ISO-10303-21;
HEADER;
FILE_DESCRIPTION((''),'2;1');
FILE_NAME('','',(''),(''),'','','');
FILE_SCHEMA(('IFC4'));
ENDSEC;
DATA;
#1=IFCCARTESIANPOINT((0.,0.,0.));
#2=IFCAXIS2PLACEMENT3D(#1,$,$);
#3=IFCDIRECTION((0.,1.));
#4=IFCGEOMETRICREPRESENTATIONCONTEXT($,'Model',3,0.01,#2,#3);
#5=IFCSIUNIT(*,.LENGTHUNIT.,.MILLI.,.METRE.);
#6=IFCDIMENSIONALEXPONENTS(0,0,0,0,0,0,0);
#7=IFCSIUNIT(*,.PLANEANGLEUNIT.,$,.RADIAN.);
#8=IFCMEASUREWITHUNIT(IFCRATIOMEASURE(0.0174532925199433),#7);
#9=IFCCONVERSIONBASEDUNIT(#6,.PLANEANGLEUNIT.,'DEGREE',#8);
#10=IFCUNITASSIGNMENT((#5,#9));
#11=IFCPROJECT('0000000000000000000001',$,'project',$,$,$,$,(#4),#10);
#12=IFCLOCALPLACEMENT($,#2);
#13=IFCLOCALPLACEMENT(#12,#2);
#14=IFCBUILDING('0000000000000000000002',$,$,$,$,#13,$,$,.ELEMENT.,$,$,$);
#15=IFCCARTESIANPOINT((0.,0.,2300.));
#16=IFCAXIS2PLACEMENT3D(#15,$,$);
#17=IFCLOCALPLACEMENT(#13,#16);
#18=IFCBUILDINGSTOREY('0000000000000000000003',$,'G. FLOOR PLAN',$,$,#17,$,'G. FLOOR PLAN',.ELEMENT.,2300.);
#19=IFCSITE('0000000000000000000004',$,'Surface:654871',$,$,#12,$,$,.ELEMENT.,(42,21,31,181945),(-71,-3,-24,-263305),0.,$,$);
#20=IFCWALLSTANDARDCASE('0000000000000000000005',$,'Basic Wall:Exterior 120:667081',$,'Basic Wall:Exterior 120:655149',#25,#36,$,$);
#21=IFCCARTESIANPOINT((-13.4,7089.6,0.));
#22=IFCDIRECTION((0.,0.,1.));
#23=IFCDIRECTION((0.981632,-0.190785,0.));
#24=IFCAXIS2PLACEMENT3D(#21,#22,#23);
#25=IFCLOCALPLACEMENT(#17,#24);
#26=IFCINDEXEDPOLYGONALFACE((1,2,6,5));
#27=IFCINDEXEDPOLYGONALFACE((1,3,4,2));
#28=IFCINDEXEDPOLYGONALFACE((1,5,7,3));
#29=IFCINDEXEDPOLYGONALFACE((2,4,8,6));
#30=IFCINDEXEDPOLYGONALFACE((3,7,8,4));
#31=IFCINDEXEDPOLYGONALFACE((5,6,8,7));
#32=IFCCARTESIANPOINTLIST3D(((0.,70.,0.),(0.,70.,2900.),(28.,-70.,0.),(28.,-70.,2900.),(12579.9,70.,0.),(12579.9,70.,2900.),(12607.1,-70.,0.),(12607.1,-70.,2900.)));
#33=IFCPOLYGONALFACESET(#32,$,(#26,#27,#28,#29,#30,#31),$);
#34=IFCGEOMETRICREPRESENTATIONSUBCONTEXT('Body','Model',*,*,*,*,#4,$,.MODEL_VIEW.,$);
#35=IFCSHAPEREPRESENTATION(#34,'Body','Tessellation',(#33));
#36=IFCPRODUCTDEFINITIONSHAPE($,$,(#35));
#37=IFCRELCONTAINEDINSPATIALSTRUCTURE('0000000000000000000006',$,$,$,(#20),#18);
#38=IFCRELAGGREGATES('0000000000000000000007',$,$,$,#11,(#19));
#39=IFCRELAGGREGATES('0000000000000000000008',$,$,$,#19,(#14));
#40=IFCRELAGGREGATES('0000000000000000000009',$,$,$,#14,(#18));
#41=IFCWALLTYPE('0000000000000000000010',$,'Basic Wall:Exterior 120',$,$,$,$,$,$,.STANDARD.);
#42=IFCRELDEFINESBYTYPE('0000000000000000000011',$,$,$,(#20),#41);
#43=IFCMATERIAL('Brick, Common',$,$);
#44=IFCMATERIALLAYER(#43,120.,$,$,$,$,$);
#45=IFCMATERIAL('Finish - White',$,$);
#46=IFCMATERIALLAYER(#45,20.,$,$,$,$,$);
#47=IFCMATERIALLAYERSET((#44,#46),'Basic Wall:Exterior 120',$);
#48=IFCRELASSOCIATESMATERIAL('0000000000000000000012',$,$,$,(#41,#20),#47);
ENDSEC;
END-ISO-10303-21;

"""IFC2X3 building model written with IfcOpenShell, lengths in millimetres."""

from ifc_helpers import new_model, entity, si_unit, converted_unit, direction, frame, origin, place, context, subcontext, project, spatial, polyline, outline, extrude, clip, bounded_halfspace, material, layer, layer_set, layer_usage, type_object, element, save


model = new_model("IFC2X3")

# Units and contexts
model_context = context("Model", 3, precision=0.01, world=origin(), true_north=direction((0.0, 1.0)))
body_context = subcontext(model_context, "Body", "Model", "MODEL_VIEW")
ifc_project = project(units=[si_unit("LENGTHUNIT", "METRE", prefix="MILLI"), converted_unit("PLANEANGLEUNIT", "DEGREE", entity("IfcRatioMeasure", 0.0174532925199433), si_unit("PLANEANGLEUNIT", "RADIAN"), dimensions=[0, 0, 0, 0, 0, 0, 0])], contexts=[model_context])

# Site, building, storey
site_placement = place(None, origin())
site = spatial("IfcSite", under=ifc_project, at=site_placement, Name="Surface:654871", CompositionType="ELEMENT", RefLatitude=(42, 21, 31, 181945), RefLongitude=(-71, -3, -24, -263305), RefElevation=0.0)
building_placement = place(site_placement, origin())
building = spatial("IfcBuilding", under=site, at=building_placement, CompositionType="ELEMENT")
storey_placement = place(building_placement, frame((0.0, 0.0, 2300.0)))
storey = spatial("IfcBuildingStorey", under=building, at=storey_placement, Name="G. FLOOR PLAN", LongName="G. FLOOR PLAN", CompositionType="ELEMENT", Elevation=2300.0)

# Wall
ifc_material_1 = material(Name="Brick, Common")
ifc_layer_1 = layer(ifc_material_1, 120.0)
ifc_material_2 = material(Name="Finish - White")
ifc_layer_2 = layer(ifc_material_2, 20.0)
ifc_layer_set_1 = layer_set([ifc_layer_1, ifc_layer_2], Name="Basic Wall:Exterior 120")
ifc_layer_usage_1 = layer_usage(ifc_layer_set_1, "AXIS2", "NEGATIVE", 70.0)
wall_type_1 = type_object("IfcWallType", Name="Basic Wall:Exterior 120", PredefinedType="STANDARD", material=ifc_layer_set_1)
wall_1_placement = place(storey_placement, frame((-13.4, 7089.6, 0.0), z_axis=(0.0, 0.0, 1.0), x_axis=(0.981632, -0.190785, 0.0)))
element("IfcWallStandardCase", 1, at=wall_1_placement, inside=storey, type_object=wall_type_1, material=ifc_layer_usage_1, Name="Basic Wall:Exterior 120:667081", ObjectType="Basic Wall:Exterior 120:655149", context=body_context, shape_type="Clipping", body=[
    clip(extrude(outline(polyline([(12607.1, -70.0), (12579.9, 70.0), (0.0, 70.0), (28.0, -70.0), (170.7, -70.0), (5520.3, -70.0), (5683.3, -70.0), (10304.9, -70.0), (10467.9, -70.0), (12464.5, -70.0), (12607.1, -70.0)])), origin(), (0.0, 0.0, 1.0), 2900.0), bounded_halfspace(frame((28.0, -70.0, 2900.0), z_axis=(0.0, 0.0, -1.0), x_axis=(1.0, -0.000001, 0.0)), True, frame((28.0, -70.0, 2900.0)), polyline([(0.0, 0.0), (142.8, 0.0), (5492.3, 0.0), (5655.3, 0.0), (12436.6, 0.0), (12579.2, 0.0), (12552.0, 140.0), (-28.0, 140.0), (0.0, 0.0)]))),
])

save(model, "model.ifc")
